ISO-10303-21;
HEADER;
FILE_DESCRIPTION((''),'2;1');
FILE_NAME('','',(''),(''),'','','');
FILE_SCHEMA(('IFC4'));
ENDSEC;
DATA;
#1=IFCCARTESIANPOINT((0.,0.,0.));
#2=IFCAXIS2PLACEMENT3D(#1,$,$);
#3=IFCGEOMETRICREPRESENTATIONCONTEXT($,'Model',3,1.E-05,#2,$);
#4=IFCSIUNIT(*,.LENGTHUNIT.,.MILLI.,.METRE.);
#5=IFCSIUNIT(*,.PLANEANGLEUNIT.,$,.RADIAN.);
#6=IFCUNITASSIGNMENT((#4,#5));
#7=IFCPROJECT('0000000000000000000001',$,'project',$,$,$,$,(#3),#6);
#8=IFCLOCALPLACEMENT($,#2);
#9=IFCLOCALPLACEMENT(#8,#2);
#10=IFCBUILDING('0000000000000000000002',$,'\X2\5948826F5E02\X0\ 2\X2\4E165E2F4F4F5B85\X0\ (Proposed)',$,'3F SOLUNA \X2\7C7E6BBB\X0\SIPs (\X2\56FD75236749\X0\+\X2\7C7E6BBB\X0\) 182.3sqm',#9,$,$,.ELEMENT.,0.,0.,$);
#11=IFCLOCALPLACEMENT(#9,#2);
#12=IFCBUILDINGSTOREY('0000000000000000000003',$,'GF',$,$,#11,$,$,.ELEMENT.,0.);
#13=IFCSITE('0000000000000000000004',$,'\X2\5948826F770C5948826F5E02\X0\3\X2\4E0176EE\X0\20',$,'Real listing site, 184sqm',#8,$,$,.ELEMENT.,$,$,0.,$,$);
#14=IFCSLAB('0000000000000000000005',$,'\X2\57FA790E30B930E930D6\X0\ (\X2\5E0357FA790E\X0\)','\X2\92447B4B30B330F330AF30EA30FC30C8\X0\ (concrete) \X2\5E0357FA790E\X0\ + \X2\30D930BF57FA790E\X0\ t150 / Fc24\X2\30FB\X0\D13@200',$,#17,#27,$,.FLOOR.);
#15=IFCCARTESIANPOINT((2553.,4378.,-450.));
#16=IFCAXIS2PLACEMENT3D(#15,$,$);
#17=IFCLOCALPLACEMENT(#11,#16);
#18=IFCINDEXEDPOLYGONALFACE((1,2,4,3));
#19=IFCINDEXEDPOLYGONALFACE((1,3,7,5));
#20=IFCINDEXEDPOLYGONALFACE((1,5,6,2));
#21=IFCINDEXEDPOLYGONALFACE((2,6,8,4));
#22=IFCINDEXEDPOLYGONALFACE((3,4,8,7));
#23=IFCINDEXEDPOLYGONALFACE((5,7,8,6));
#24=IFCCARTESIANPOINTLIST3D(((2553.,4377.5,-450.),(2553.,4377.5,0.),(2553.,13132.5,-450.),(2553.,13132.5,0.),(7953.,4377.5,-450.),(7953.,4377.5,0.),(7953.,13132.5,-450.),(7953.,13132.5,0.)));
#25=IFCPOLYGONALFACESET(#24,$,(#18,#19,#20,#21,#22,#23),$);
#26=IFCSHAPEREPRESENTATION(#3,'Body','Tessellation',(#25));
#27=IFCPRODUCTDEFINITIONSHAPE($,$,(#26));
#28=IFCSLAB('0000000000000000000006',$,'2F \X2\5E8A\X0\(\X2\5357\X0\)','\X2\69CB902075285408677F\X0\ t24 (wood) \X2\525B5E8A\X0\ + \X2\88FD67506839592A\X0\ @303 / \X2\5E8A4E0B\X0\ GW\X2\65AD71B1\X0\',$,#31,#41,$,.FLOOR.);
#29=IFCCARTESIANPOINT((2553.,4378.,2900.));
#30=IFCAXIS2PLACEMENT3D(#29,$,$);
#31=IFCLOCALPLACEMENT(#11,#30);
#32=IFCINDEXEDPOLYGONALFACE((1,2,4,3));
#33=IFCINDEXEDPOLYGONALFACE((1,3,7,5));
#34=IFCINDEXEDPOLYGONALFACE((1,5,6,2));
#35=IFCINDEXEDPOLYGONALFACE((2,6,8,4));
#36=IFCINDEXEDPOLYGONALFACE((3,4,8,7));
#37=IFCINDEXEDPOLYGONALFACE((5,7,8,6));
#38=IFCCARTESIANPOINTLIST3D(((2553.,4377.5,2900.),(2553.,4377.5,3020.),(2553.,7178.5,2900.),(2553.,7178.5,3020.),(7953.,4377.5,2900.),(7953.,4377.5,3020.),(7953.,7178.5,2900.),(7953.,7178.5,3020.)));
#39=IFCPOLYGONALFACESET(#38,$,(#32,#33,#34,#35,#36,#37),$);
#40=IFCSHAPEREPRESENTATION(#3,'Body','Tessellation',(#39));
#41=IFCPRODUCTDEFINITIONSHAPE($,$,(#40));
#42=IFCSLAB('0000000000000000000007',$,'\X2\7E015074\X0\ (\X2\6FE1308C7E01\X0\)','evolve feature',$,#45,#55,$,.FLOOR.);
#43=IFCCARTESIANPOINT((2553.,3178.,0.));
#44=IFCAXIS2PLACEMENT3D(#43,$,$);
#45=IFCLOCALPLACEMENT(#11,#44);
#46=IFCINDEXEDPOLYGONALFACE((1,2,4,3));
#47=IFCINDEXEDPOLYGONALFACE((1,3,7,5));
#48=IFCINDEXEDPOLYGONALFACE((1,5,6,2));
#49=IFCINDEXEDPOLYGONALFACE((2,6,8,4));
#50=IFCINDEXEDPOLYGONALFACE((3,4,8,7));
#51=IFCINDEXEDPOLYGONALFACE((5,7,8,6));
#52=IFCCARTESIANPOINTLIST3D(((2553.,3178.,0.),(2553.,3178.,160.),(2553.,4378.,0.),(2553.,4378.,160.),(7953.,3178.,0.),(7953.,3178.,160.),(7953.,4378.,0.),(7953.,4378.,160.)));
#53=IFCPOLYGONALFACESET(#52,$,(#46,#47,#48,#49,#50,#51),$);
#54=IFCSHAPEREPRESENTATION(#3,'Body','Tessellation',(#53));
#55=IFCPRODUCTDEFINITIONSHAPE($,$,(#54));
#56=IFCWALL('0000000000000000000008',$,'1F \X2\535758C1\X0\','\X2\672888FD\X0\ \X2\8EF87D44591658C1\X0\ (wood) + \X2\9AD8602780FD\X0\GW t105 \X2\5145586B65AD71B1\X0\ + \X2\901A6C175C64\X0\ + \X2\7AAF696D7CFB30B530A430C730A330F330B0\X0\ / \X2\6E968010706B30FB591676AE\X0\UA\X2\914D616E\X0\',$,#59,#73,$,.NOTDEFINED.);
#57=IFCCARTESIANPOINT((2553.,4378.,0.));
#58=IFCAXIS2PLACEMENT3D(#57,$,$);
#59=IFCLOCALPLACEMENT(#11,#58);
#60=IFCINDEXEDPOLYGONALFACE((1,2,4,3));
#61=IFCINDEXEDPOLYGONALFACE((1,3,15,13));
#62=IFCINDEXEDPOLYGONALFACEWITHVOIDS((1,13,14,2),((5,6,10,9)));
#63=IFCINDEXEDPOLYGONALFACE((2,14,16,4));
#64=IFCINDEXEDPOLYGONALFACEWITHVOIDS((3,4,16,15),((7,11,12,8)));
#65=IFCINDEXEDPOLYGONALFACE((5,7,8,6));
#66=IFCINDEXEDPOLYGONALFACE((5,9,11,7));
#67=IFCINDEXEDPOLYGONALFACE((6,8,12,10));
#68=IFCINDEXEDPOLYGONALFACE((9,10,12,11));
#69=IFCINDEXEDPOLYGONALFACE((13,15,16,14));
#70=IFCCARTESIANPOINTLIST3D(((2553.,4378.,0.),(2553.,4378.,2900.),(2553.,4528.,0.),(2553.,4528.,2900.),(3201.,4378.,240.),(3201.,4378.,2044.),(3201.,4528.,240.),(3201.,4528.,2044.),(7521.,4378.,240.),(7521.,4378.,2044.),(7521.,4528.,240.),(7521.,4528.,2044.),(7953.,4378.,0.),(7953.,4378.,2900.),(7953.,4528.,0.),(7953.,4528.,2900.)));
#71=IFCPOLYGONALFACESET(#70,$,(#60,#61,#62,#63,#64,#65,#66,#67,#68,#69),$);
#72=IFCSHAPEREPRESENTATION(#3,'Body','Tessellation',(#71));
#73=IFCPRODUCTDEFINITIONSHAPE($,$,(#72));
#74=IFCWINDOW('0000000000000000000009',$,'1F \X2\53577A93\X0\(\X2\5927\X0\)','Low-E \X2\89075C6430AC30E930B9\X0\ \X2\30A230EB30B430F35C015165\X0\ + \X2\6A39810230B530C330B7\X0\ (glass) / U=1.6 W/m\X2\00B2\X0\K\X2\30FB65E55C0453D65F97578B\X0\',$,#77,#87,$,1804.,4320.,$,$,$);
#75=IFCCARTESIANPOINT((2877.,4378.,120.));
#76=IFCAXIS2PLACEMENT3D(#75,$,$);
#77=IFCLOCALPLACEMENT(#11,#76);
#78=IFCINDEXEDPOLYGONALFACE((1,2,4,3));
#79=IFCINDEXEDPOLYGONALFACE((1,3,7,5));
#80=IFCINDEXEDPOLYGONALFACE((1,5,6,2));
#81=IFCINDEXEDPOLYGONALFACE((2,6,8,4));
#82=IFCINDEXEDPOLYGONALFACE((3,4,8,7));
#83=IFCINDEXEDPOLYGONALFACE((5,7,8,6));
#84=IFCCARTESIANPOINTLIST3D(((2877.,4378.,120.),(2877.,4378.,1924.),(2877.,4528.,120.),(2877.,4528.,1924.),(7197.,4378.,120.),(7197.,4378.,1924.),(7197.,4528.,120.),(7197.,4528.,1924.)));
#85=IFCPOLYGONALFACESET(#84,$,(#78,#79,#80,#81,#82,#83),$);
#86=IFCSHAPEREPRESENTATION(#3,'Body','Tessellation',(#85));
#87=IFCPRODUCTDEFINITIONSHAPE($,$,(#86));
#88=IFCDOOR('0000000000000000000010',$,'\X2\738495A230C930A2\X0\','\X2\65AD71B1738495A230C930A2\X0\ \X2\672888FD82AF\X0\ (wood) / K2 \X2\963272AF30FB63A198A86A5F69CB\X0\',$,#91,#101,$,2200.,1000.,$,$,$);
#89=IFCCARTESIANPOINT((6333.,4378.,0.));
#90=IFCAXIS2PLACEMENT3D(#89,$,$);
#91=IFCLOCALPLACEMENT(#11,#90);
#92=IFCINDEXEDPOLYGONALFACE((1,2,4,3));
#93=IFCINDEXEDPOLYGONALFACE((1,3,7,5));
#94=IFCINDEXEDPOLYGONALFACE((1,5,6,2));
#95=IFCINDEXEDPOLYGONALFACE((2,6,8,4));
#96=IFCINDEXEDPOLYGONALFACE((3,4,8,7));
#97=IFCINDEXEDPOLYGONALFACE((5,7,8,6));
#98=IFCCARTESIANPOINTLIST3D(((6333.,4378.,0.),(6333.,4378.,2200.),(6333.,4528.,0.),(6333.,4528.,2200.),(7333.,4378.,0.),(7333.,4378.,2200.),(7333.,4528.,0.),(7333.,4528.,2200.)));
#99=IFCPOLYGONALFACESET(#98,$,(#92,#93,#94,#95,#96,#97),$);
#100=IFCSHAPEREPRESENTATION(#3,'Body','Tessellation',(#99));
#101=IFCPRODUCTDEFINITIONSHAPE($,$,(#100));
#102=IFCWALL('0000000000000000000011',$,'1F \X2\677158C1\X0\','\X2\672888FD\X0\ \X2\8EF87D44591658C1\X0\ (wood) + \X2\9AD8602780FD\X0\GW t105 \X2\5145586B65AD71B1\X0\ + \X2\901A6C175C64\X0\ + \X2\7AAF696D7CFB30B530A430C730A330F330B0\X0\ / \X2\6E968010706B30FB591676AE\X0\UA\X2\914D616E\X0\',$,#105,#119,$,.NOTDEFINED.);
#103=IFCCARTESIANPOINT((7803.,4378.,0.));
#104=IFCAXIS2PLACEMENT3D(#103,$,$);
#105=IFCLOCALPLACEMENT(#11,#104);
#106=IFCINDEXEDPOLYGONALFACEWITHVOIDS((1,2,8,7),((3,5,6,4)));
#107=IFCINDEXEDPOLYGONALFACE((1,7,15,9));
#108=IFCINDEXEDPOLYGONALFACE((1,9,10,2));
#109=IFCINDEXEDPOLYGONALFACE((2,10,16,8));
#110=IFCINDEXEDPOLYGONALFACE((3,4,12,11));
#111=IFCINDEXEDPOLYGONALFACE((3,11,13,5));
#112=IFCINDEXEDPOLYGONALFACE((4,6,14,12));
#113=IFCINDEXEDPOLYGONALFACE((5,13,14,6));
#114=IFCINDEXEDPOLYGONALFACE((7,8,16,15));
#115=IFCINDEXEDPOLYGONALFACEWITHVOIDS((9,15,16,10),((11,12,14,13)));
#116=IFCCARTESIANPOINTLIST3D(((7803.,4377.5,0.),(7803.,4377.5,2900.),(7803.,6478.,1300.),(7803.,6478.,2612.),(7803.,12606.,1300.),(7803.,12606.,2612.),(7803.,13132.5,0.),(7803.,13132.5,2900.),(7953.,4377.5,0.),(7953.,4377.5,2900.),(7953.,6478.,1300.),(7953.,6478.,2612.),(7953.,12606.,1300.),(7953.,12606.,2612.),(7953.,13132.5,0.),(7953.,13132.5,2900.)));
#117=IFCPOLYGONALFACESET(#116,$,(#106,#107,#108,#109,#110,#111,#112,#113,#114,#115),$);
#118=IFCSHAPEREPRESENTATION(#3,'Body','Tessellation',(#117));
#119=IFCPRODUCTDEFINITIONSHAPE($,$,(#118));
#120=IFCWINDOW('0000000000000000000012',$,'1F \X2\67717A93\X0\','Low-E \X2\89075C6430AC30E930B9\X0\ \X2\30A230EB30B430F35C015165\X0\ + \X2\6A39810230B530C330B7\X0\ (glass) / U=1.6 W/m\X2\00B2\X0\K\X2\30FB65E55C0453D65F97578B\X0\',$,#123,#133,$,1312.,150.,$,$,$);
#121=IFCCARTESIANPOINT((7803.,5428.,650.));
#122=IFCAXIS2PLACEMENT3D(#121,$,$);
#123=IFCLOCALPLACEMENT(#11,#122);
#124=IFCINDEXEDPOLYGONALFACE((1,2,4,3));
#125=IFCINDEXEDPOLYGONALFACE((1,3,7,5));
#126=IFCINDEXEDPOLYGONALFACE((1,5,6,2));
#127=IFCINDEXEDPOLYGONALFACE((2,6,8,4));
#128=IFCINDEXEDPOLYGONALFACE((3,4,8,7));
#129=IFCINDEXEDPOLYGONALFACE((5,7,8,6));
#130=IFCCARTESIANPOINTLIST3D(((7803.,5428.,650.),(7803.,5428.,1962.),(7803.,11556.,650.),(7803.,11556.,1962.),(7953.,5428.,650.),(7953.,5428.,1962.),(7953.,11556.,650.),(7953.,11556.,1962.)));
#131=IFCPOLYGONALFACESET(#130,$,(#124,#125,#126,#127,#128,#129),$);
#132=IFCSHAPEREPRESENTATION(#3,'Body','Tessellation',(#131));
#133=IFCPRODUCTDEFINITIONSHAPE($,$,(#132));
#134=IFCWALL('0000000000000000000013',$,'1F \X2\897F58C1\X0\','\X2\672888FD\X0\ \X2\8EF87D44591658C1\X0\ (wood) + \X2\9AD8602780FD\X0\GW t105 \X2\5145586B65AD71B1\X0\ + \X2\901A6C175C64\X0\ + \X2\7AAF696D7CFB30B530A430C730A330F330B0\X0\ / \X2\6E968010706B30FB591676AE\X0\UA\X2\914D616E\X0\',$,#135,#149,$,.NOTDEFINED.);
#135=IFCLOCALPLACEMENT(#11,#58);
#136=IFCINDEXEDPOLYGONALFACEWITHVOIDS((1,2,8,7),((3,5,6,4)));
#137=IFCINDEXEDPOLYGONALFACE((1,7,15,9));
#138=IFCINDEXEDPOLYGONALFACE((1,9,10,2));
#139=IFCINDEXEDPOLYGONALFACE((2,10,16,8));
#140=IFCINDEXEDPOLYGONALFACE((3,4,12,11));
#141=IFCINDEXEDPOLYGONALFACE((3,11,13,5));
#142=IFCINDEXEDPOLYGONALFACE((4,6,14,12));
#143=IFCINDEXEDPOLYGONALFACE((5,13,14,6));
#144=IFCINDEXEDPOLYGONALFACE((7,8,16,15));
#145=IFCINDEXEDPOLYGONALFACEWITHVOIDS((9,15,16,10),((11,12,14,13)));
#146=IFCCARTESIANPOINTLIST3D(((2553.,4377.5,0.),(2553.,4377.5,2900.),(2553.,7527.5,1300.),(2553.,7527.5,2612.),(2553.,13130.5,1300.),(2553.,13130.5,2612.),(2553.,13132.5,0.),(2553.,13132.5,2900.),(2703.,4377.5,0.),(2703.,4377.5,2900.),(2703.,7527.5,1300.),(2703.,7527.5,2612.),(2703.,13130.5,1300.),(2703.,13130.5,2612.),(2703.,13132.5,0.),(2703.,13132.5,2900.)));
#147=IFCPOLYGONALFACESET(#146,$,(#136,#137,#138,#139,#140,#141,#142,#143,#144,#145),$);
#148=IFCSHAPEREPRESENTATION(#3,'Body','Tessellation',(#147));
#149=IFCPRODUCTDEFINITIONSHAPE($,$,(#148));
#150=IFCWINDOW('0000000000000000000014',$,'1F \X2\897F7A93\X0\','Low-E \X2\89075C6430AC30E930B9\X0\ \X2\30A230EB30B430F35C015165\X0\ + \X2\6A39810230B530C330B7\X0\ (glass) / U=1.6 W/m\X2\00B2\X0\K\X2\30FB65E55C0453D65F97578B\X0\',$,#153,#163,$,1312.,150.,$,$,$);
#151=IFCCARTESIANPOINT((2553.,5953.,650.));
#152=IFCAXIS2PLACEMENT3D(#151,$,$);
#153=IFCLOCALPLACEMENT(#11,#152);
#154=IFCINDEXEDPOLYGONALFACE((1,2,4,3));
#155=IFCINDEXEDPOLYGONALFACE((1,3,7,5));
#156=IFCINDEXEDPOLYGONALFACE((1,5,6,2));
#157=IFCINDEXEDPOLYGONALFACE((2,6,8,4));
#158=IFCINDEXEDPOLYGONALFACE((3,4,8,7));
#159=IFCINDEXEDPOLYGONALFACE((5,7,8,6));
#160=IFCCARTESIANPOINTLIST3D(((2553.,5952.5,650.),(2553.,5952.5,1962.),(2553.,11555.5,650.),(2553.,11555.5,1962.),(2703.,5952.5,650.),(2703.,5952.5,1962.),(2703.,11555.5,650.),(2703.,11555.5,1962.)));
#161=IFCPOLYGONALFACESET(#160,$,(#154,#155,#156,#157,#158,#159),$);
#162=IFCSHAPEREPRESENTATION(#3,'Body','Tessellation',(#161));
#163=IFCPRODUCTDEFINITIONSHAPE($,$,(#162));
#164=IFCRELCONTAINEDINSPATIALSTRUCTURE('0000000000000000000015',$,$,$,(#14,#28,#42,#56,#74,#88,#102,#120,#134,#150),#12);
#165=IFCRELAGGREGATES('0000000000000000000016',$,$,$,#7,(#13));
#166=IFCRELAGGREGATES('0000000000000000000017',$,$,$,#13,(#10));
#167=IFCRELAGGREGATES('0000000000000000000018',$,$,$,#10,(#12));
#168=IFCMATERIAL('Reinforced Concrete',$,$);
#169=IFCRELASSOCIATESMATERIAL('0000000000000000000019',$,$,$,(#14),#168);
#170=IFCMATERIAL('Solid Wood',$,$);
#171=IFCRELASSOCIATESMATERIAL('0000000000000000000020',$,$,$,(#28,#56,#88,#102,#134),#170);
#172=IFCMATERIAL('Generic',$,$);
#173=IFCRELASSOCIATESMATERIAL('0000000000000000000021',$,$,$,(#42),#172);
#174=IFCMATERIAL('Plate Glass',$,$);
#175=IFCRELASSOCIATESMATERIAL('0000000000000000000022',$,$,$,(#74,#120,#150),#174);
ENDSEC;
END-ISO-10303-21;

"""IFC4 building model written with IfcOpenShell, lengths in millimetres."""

from ifc_helpers import new_model, si_unit, frame, frame_2d, origin, place, context, project, spatial, rectangle, extrude, material, element, fill, save


model = new_model("IFC4")

# Units and contexts
model_context = context("Model", 3, precision=1e-05, world=origin())
ifc_project = project(units=[si_unit("LENGTHUNIT", "METRE", prefix="MILLI"), si_unit("PLANEANGLEUNIT", "RADIAN")], contexts=[model_context])

# Site, building, storey
site_placement = place(None, origin())
site = spatial("IfcSite", under=ifc_project, at=site_placement, Name="奈良県奈良市3丁目20", ObjectType="Real listing site, 184sqm", CompositionType="ELEMENT", RefElevation=0.0)
building_placement = place(site_placement, origin())
building = spatial("IfcBuilding", under=site, at=building_placement, Name="奈良市 2世帯住宅 (Proposed)", ObjectType="3F SOLUNA 籾殻SIPs (国産杉+籾殻) 182.3sqm", CompositionType="ELEMENT", ElevationOfRefHeight=0.0, ElevationOfTerrain=0.0)
storey_placement = place(building_placement, origin())
storey = spatial("IfcBuildingStorey", under=building, at=storey_placement, Name="GF", CompositionType="ELEMENT", Elevation=0.0)

# Slabs
ifc_material_1 = material(Name="Reinforced Concrete")
slab_1_placement = place(storey_placement, frame((2553.0, 4378.0, -450.0)))
element("IfcSlab", 1, at=slab_1_placement, inside=storey, material=ifc_material_1, Name="基礎スラブ (布基礎)", Description="鉄筋コンクリート (concrete) 布基礎 + ベタ基礎 t150 / Fc24・D13@200", PredefinedType="FLOOR", context=model_context, shape_type="SweptSolid", body=[
    extrude(rectangle(XDim=5400.0, YDim=8755.0, at=frame_2d((2700.0, 4377.0))), frame((2553.0, 4378.0, -450.0)), (0.0, 0.0, 1.0), 450.0),
])
ifc_material_2 = material(Name="Solid Wood")
slab_2_placement = place(storey_placement, frame((2553.0, 4378.0, 2900.0)))
element("IfcSlab", 2, at=slab_2_placement, inside=storey, material=ifc_material_2, Name="2F 床(南)", Description="構造用合板 t24 (wood) 剛床 + 製材根太 @303 / 床下 GW断熱", PredefinedType="FLOOR", context=model_context, shape_type="SweptSolid", body=[
    extrude(rectangle(XDim=5400.0, YDim=2801.0, at=frame_2d((2700.0, 1400.0))), frame((2553.0, 4378.0, 2900.0)), (0.0, 0.0, 1.0), 120.0),
])
ifc_material_3 = material(Name="Generic")
slab_3_placement = place(storey_placement, frame((2553.0, 3178.0, 0.0)))
element("IfcSlab", 3, at=slab_3_placement, inside=storey, material=ifc_material_3, Name="縁側 (濡れ縁)", Description="evolve feature", PredefinedType="FLOOR", context=model_context, shape_type="SweptSolid", body=[
    extrude(rectangle(XDim=5400.0, YDim=1200.0, at=frame_2d((2700.0, 600.0))), frame((2553.0, 3178.0, 0.0)), (0.0, 0.0, 1.0), 160.0),
])

# Wall, openings, window, door
wall_1_placement = place(storey_placement, frame((2553.0, 4378.0, 0.0)))
wall_1 = element("IfcWall", 4, at=wall_1_placement, inside=storey, material=ifc_material_2, Name="1F 南壁", Description="木製 軸組外壁 (wood) + 高性能GW t105 充填断熱 + 通気層 + 窯業系サイディング / 準耐火・外皮UA配慮", PredefinedType="NOTDEFINED", context=model_context, shape_type="SweptSolid", body=[
    extrude(rectangle(XDim=5400.0, YDim=150.0, at=frame_2d((2700.0, 75.0))), frame((2553.0, 4378.0, 0.0)), (0.0, 0.0, 1.0), 2900.0),
])
opening_1_placement = place(storey_placement, frame((2877.0, 4378.0, 120.0)))
opening_1 = element("IfcOpeningElement", 5, at=opening_1_placement, cuts=wall_1, PredefinedType="NOTDEFINED", context=model_context, shape_type="SweptSolid", body=[
    extrude(rectangle(XDim=4320.0, YDim=150.0, at=frame_2d((2160.0, 75.0))), frame((2877.0, 4378.0, 120.0)), (0.0, 0.0, 1.0), 1804.0),
])
opening_2_placement = place(storey_placement, frame((6333.0, 4378.0, 0.0)))
opening_2 = element("IfcOpeningElement", 6, at=opening_2_placement, cuts=wall_1, PredefinedType="NOTDEFINED", context=model_context, shape_type="SweptSolid", body=[
    extrude(rectangle(XDim=1000.0, YDim=150.0, at=frame_2d((500.0, 75.0))), frame((6333.0, 4378.0, 0.0)), (0.0, 0.0, 1.0), 2200.0),
])
ifc_material_4 = material(Name="Plate Glass")
window_1_placement = place(storey_placement, frame((2877.0, 4378.0, 120.0)))
window_1 = element("IfcWindow", 7, at=window_1_placement, inside=storey, material=ifc_material_4, Name="1F 南窓(大)", Description="Low-E 複層ガラス アルゴン封入 + 樹脂サッシ (glass) / U=1.6 W/m²K・日射取得型", OverallHeight=1804.0, OverallWidth=4320.0, context=model_context, shape_type="SweptSolid", body=[
    extrude(rectangle(XDim=4320.0, YDim=150.0, at=frame_2d((2160.0, 75.0))), frame((2877.0, 4378.0, 120.0)), (0.0, 0.0, 1.0), 1804.0),
])
fill(opening_1, window_1)
door_placement = place(storey_placement, frame((6333.0, 4378.0, 0.0)))
door = element("IfcDoor", 8, at=door_placement, inside=storey, material=ifc_material_2, Name="玄関ドア", Description="断熱玄関ドア 木製芯 (wood) / K2 防犯・採風機構", OverallHeight=2200.0, OverallWidth=1000.0, context=model_context, shape_type="SweptSolid", body=[
    extrude(rectangle(XDim=1000.0, YDim=150.0, at=frame_2d((500.0, 75.0))), frame((6333.0, 4378.0, 0.0)), (0.0, 0.0, 1.0), 2200.0),
])
fill(opening_2, door)

# Walls, openings, windows
wall_2_placement = place(storey_placement, frame((7803.0, 4378.0, 0.0)))
wall_2 = element("IfcWall", 9, at=wall_2_placement, inside=storey, material=ifc_material_2, Name="1F 東壁", Description="木製 軸組外壁 (wood) + 高性能GW t105 充填断熱 + 通気層 + 窯業系サイディング / 準耐火・外皮UA配慮", PredefinedType="NOTDEFINED", context=model_context, shape_type="SweptSolid", body=[
    extrude(rectangle(XDim=150.0, YDim=8755.0, at=frame_2d((75.0, 4377.0))), frame((7803.0, 4378.0, 0.0)), (0.0, 0.0, 1.0), 2900.0),
])
opening_3_placement = place(storey_placement, frame((7803.0, 5428.0, 650.0)))
opening_3 = element("IfcOpeningElement", 10, at=opening_3_placement, cuts=wall_2, PredefinedType="NOTDEFINED", context=model_context, shape_type="SweptSolid", body=[
    extrude(rectangle(XDim=150.0, YDim=6128.0, at=frame_2d((75.0, 3064.0))), frame((7803.0, 5428.0, 650.0)), (0.0, 0.0, 1.0), 1312.0),
])
window_2_placement = place(storey_placement, frame((7803.0, 5428.0, 650.0)))
window_2 = element("IfcWindow", 11, at=window_2_placement, inside=storey, material=ifc_material_4, Name="1F 東窓", Description="Low-E 複層ガラス アルゴン封入 + 樹脂サッシ (glass) / U=1.6 W/m²K・日射取得型", OverallHeight=1312.0, OverallWidth=150.0, context=model_context, shape_type="SweptSolid", body=[
    extrude(rectangle(XDim=150.0, YDim=6128.0, at=frame_2d((75.0, 3064.0))), frame((7803.0, 5428.0, 650.0)), (0.0, 0.0, 1.0), 1312.0),
])
fill(opening_3, window_2)
wall_3_placement = place(storey_placement, frame((2553.0, 4378.0, 0.0)))
wall_3 = element("IfcWall", 12, at=wall_3_placement, inside=storey, material=ifc_material_2, Name="1F 西壁", Description="木製 軸組外壁 (wood) + 高性能GW t105 充填断熱 + 通気層 + 窯業系サイディング / 準耐火・外皮UA配慮", PredefinedType="NOTDEFINED", context=model_context, shape_type="SweptSolid", body=[
    extrude(rectangle(XDim=150.0, YDim=8755.0, at=frame_2d((75.0, 4377.0))), frame((2553.0, 4378.0, 0.0)), (0.0, 0.0, 1.0), 2900.0),
])
opening_4_placement = place(storey_placement, frame((2553.0, 5953.0, 650.0)))
opening_4 = element("IfcOpeningElement", 13, at=opening_4_placement, cuts=wall_3, PredefinedType="NOTDEFINED", context=model_context, shape_type="SweptSolid", body=[
    extrude(rectangle(XDim=150.0, YDim=5603.0, at=frame_2d((75.0, 2801.0))), frame((2553.0, 5953.0, 650.0)), (0.0, 0.0, 1.0), 1312.0),
])
window_3_placement = place(storey_placement, frame((2553.0, 5953.0, 650.0)))
window_3 = element("IfcWindow", 14, at=window_3_placement, inside=storey, material=ifc_material_4, Name="1F 西窓", Description="Low-E 複層ガラス アルゴン封入 + 樹脂サッシ (glass) / U=1.6 W/m²K・日射取得型", OverallHeight=1312.0, OverallWidth=150.0, context=model_context, shape_type="SweptSolid", body=[
    extrude(rectangle(XDim=150.0, YDim=5603.0, at=frame_2d((75.0, 2801.0))), frame((2553.0, 5953.0, 650.0)), (0.0, 0.0, 1.0), 1312.0),
])
fill(opening_4, window_3)

save(model, "model.ifc")
